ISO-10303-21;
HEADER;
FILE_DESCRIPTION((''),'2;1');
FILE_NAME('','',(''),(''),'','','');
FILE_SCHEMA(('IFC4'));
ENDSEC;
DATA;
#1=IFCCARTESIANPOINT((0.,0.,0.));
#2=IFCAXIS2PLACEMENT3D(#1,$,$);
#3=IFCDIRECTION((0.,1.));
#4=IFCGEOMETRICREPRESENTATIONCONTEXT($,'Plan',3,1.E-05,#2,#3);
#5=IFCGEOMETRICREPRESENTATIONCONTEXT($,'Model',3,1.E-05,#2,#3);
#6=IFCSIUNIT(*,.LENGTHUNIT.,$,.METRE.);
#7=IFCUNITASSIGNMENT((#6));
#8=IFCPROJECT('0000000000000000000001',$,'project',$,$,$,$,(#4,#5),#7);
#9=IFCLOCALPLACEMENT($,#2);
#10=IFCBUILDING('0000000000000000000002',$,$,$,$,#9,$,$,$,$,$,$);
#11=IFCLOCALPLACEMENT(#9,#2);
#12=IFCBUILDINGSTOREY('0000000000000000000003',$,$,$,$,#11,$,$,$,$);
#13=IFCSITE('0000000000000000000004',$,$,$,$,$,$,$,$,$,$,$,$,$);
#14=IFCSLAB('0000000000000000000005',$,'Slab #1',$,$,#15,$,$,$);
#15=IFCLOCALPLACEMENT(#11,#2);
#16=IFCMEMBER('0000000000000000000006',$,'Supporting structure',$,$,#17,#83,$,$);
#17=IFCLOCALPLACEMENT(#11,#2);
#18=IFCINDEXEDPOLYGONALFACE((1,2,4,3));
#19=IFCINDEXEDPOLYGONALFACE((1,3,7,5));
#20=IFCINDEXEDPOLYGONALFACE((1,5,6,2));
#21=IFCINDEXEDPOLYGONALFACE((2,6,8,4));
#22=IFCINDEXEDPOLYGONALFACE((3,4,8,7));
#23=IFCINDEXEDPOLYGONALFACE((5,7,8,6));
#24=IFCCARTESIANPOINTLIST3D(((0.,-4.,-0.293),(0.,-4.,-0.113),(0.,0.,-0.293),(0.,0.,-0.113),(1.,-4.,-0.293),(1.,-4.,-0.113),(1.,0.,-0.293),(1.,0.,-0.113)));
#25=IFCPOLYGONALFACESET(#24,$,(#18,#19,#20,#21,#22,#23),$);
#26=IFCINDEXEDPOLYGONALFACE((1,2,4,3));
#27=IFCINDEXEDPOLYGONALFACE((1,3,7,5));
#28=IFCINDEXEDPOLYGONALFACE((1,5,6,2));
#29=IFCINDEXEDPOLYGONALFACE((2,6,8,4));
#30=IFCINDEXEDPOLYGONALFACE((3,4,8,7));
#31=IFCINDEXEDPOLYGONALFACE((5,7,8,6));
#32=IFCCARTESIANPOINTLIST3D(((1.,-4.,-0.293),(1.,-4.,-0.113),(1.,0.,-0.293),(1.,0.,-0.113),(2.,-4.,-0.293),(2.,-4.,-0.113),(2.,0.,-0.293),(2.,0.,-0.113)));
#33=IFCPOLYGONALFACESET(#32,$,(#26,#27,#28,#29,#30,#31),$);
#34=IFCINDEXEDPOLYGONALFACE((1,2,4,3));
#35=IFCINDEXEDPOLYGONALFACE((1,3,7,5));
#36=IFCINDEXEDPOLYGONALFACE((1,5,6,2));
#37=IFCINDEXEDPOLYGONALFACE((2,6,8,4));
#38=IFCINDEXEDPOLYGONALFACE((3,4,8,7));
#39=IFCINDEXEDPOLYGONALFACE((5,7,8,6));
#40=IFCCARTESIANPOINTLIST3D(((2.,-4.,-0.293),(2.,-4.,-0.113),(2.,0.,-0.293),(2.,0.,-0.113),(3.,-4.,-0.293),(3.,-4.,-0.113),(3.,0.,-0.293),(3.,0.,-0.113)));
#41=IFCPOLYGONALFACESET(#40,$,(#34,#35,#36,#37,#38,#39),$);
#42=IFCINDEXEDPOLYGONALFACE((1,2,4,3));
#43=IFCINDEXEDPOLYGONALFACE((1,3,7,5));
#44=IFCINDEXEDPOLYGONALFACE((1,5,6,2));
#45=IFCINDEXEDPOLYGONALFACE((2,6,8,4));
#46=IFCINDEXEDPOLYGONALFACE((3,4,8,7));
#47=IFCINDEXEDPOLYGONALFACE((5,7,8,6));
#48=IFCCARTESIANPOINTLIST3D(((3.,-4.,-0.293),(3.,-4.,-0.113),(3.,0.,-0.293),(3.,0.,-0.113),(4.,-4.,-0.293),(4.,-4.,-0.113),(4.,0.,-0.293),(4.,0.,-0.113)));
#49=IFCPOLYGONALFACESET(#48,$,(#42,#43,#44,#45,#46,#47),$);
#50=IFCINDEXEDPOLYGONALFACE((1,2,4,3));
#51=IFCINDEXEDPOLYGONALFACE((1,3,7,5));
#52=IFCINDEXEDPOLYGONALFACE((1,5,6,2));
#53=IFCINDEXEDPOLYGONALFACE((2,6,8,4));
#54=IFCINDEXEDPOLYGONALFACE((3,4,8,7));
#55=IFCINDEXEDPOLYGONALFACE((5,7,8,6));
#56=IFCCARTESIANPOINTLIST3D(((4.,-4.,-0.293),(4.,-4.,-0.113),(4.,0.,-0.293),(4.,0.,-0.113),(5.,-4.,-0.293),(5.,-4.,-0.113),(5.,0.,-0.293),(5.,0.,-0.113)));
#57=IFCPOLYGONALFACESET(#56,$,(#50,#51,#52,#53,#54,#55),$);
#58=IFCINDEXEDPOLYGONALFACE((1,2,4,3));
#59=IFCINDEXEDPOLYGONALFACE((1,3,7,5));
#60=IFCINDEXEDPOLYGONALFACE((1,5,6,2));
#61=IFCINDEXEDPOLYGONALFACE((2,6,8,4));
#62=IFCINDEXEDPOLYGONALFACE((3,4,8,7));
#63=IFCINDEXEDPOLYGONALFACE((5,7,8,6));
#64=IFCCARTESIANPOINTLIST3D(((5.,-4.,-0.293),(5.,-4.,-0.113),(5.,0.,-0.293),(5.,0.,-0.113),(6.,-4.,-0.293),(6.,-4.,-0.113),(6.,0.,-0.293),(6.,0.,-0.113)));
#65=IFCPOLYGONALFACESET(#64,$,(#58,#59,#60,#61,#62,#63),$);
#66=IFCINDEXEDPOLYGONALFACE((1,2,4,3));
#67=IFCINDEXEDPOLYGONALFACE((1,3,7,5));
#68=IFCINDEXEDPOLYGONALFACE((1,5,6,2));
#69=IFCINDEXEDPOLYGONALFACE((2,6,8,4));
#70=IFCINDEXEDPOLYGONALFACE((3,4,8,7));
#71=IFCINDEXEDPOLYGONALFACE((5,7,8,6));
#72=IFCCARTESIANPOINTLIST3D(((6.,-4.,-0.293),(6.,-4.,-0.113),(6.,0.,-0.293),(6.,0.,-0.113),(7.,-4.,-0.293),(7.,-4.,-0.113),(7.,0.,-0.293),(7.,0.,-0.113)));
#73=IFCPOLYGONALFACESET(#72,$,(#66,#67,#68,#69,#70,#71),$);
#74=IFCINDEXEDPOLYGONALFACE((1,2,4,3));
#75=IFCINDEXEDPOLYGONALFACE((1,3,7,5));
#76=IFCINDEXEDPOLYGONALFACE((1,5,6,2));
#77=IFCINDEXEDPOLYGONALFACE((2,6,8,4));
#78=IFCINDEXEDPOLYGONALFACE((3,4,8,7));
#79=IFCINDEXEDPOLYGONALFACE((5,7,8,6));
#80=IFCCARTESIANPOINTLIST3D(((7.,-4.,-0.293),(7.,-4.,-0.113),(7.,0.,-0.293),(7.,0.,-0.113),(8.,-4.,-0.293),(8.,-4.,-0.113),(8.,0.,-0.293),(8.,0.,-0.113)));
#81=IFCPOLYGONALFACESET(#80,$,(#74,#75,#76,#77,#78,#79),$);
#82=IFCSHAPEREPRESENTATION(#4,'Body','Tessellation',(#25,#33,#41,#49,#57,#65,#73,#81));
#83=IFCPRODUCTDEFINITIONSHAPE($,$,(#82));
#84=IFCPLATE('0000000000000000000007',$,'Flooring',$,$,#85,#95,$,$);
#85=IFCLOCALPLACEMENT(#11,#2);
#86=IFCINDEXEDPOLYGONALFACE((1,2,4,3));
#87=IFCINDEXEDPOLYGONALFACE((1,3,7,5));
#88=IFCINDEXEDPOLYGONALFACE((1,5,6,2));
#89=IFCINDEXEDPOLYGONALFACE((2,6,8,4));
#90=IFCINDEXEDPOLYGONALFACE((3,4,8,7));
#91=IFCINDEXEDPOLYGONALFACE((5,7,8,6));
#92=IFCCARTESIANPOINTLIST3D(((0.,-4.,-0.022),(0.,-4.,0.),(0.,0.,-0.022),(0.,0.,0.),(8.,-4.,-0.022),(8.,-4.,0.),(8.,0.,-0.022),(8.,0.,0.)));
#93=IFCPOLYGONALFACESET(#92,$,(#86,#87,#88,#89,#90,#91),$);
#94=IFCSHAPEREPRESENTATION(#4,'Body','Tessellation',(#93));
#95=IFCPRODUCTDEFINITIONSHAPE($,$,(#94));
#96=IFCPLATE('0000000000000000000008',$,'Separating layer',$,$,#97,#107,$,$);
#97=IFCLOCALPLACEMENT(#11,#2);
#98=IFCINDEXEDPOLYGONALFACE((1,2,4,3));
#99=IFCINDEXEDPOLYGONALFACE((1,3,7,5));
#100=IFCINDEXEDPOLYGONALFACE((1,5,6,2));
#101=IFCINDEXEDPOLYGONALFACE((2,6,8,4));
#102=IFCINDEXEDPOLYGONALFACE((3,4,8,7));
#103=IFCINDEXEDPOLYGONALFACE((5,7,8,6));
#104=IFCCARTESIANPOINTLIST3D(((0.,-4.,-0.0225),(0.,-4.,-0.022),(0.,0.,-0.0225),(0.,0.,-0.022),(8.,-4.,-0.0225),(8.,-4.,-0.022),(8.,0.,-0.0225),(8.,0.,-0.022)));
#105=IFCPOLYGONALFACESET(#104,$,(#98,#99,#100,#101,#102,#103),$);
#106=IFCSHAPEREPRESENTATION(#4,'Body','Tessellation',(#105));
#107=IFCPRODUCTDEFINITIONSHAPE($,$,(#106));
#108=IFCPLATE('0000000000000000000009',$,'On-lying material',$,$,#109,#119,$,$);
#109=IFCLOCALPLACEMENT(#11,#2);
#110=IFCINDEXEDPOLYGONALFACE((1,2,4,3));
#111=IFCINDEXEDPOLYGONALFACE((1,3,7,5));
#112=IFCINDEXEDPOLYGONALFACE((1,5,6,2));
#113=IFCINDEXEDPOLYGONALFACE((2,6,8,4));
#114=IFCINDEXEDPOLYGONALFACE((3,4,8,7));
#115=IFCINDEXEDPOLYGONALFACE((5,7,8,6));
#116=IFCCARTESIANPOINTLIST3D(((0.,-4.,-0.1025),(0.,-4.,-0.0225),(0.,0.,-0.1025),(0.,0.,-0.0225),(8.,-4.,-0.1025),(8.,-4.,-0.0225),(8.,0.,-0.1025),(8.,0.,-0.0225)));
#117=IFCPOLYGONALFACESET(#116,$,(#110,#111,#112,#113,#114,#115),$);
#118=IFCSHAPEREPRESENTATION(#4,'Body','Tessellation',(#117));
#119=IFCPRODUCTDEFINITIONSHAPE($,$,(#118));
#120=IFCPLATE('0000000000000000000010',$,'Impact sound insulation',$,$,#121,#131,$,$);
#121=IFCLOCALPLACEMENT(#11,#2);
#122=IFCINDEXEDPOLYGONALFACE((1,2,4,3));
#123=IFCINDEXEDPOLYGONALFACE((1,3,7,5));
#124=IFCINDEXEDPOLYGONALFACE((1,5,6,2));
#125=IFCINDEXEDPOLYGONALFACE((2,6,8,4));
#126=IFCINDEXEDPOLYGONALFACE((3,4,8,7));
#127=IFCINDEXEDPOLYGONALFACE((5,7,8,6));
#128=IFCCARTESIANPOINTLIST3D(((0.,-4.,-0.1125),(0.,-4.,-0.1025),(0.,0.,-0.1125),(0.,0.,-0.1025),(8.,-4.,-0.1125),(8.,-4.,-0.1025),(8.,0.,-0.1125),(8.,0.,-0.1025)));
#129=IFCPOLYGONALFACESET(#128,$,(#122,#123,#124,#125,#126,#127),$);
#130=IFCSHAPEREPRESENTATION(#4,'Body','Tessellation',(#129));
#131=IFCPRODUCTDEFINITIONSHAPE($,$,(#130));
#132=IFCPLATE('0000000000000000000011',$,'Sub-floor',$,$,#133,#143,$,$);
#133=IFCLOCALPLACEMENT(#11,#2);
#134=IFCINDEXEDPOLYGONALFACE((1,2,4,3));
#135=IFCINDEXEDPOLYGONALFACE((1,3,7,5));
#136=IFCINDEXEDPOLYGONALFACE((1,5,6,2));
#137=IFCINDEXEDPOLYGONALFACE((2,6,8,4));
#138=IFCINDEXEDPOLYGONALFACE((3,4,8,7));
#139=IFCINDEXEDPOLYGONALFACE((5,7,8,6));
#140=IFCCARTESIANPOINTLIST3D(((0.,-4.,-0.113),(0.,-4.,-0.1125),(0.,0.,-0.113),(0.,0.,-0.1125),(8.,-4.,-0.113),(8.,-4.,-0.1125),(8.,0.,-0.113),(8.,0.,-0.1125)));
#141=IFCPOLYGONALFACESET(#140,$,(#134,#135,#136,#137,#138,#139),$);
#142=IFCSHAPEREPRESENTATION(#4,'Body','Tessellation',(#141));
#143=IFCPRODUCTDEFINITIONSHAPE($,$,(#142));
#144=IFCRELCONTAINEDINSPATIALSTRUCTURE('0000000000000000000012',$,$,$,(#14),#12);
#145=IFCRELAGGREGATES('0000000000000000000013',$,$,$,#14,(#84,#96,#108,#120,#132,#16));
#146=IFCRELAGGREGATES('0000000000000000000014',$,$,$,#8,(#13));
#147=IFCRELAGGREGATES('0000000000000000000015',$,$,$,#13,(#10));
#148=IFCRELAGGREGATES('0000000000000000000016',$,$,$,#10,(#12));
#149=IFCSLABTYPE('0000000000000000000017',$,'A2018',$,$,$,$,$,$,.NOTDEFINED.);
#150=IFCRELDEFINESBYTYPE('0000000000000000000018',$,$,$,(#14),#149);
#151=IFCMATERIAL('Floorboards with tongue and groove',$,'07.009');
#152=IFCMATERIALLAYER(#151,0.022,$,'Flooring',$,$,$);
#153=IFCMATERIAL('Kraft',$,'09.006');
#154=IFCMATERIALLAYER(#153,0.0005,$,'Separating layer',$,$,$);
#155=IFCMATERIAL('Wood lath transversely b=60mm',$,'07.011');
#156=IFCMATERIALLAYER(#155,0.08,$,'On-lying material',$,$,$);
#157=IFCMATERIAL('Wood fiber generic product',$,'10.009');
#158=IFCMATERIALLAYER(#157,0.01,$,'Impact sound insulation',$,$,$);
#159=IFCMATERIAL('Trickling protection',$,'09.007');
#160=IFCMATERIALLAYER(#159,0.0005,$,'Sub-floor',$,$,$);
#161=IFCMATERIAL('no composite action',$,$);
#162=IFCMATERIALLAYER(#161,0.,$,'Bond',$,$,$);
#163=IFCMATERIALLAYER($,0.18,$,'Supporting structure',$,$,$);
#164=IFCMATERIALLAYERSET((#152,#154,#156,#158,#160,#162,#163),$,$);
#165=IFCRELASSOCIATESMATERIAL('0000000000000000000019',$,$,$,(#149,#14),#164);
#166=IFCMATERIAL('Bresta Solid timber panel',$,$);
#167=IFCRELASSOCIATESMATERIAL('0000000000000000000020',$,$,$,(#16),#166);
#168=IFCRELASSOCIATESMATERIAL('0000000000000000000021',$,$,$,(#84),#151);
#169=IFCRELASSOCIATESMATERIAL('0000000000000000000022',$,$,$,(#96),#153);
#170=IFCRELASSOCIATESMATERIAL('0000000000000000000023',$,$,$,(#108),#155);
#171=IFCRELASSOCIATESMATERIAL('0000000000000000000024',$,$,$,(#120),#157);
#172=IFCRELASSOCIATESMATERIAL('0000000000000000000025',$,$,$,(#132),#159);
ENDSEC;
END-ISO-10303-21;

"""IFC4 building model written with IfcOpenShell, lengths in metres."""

from ifc_helpers import new_model, si_unit, direction, frame, frame_2d, origin, origin_with_axes, place, context, project, spatial, rectangle, extrude, material, layer, layer_set, type_object, element, aggregate, save


model = new_model("IFC4")

# Units and contexts
plan_context = context("Plan", 3, precision=1e-05, world=origin(), true_north=direction((0.0, 1.0)))
model_context = context("Model", 3, precision=1e-05, world=origin(), true_north=direction((0.0, 1.0)))
ifc_project = project(units=[si_unit("LENGTHUNIT", "METRE")], contexts=[plan_context, model_context])

# Site, building, storey
site = spatial("IfcSite", under=ifc_project)
building_placement = place(None, origin())
building = spatial("IfcBuilding", under=site, at=building_placement)
storey_placement = place(building_placement, origin())
storey = spatial("IfcBuildingStorey", under=building, at=storey_placement)

# Slab, member, plates
ifc_material_1 = material(Name="Floorboards with tongue and groove", Category="07.009")
ifc_layer_1 = layer(ifc_material_1, 0.022, Name="Flooring")
ifc_material_2 = material(Name="Kraft", Category="09.006")
ifc_layer_2 = layer(ifc_material_2, 0.0005, Name="Separating layer")
ifc_material_3 = material(Name="Wood lath transversely b=60mm", Category="07.011")
ifc_layer_3 = layer(ifc_material_3, 0.08, Name="On-lying material")
ifc_material_4 = material(Name="Wood fiber generic product", Category="10.009")
ifc_layer_4 = layer(ifc_material_4, 0.01, Name="Impact sound insulation")
ifc_material_5 = material(Name="Trickling protection", Category="09.007")
ifc_layer_5 = layer(ifc_material_5, 0.0005, Name="Sub-floor")
ifc_material_6 = material(Name="no composite action")
ifc_layer_6 = layer(ifc_material_6, 0.0, Name="Bond")
ifc_layer_7 = layer(None, 0.18, Name="Supporting structure")
ifc_layer_set = layer_set([ifc_layer_1, ifc_layer_2, ifc_layer_3, ifc_layer_4, ifc_layer_5, ifc_layer_6, ifc_layer_7])
slab_type = type_object("IfcSlabType", Name="A2018", PredefinedType="NOTDEFINED", material=ifc_layer_set)
slab_placement = place(None, frame((0.0, 0.0, 0.0), z_axis=(0.0, 0.0, -1.0), x_axis=(1.0, 0.0, 0.0)))
slab = element("IfcSlab", 1, at=slab_placement, inside=storey, type_object=slab_type, material=ifc_layer_set, Name="Slab #1")
ifc_material_7 = material(Name="Bresta Solid timber panel")
member_placement = place(slab_placement, origin())
member = element("IfcMember", 2, at=member_placement, material=ifc_material_7, Name="Supporting structure", context=plan_context, shape_type="SweptSolid", body=[
    extrude(rectangle(XDim=1.0, YDim=0.18, at=frame_2d((0.5, 0.09), x_axis=(1.0, 0.0))), frame((0.0, 4.0, 0.113), z_axis=(0.0, -1.0, 0.0), x_axis=(1.0, 0.0, 0.0)), (0.0, 0.0, 1.0), 4.0),
    extrude(rectangle(XDim=1.0, YDim=0.18, at=frame_2d((0.5, 0.09), x_axis=(1.0, 0.0))), frame((1.0, 4.0, 0.113), z_axis=(0.0, -1.0, 0.0), x_axis=(1.0, 0.0, 0.0)), (0.0, 0.0, 1.0), 4.0),
    extrude(rectangle(XDim=1.0, YDim=0.18, at=frame_2d((0.5, 0.09), x_axis=(1.0, 0.0))), frame((2.0, 4.0, 0.113), z_axis=(0.0, -1.0, 0.0), x_axis=(1.0, 0.0, 0.0)), (0.0, 0.0, 1.0), 4.0),
    extrude(rectangle(XDim=1.0, YDim=0.18, at=frame_2d((0.5, 0.09), x_axis=(1.0, 0.0))), frame((3.0, 4.0, 0.113), z_axis=(0.0, -1.0, 0.0), x_axis=(1.0, 0.0, 0.0)), (0.0, 0.0, 1.0), 4.0),
    extrude(rectangle(XDim=1.0, YDim=0.18, at=frame_2d((0.5, 0.09), x_axis=(1.0, 0.0))), frame((4.0, 4.0, 0.113), z_axis=(0.0, -1.0, 0.0), x_axis=(1.0, 0.0, 0.0)), (0.0, 0.0, 1.0), 4.0),
    extrude(rectangle(XDim=1.0, YDim=0.18, at=frame_2d((0.5, 0.09), x_axis=(1.0, 0.0))), frame((5.0, 4.0, 0.113), z_axis=(0.0, -1.0, 0.0), x_axis=(1.0, 0.0, 0.0)), (0.0, 0.0, 1.0), 4.0),
    extrude(rectangle(XDim=1.0, YDim=0.18, at=frame_2d((0.5, 0.09), x_axis=(1.0, 0.0))), frame((6.0, 4.0, 0.113), z_axis=(0.0, -1.0, 0.0), x_axis=(1.0, 0.0, 0.0)), (0.0, 0.0, 1.0), 4.0),
    extrude(rectangle(XDim=1.0, YDim=0.18, at=frame_2d((0.5, 0.09), x_axis=(1.0, 0.0))), frame((7.0, 4.0, 0.113), z_axis=(0.0, -1.0, 0.0), x_axis=(1.0, 0.0, 0.0)), (0.0, 0.0, 1.0), 4.0),
])
plate_1_placement = place(slab_placement, origin())
plate_1 = element("IfcPlate", 3, at=plate_1_placement, material=ifc_material_1, Name="Flooring", context=plan_context, shape_type="SweptSolid", body=[
    extrude(rectangle(XDim=8.0, YDim=4.0, at=frame_2d((4.0, 2.0), x_axis=(1.0, 0.0))), origin_with_axes(), (0.0, 0.0, 1.0), 0.022),
])
plate_2_placement = place(slab_placement, origin())
plate_2 = element("IfcPlate", 4, at=plate_2_placement, material=ifc_material_2, Name="Separating layer", context=plan_context, shape_type="SweptSolid", body=[
    extrude(rectangle(XDim=8.0, YDim=4.0, at=frame_2d((4.0, 2.0), x_axis=(1.0, 0.0))), frame((0.0, 0.0, 0.022), z_axis=(0.0, 0.0, 1.0), x_axis=(1.0, 0.0, 0.0)), (0.0, 0.0, 1.0), 0.0005),
])
plate_3_placement = place(slab_placement, origin())
plate_3 = element("IfcPlate", 5, at=plate_3_placement, material=ifc_material_3, Name="On-lying material", context=plan_context, shape_type="SweptSolid", body=[
    extrude(rectangle(XDim=8.0, YDim=4.0, at=frame_2d((4.0, 2.0), x_axis=(1.0, 0.0))), frame((0.0, 0.0, 0.0225), z_axis=(0.0, 0.0, 1.0), x_axis=(1.0, 0.0, 0.0)), (0.0, 0.0, 1.0), 0.08),
])
plate_4_placement = place(slab_placement, origin())
plate_4 = element("IfcPlate", 6, at=plate_4_placement, material=ifc_material_4, Name="Impact sound insulation", context=plan_context, shape_type="SweptSolid", body=[
    extrude(rectangle(XDim=8.0, YDim=4.0, at=frame_2d((4.0, 2.0), x_axis=(1.0, 0.0))), frame((0.0, 0.0, 0.1025), z_axis=(0.0, 0.0, 1.0), x_axis=(1.0, 0.0, 0.0)), (0.0, 0.0, 1.0), 0.01),
])
plate_5_placement = place(slab_placement, origin())
plate_5 = element("IfcPlate", 7, at=plate_5_placement, material=ifc_material_5, Name="Sub-floor", context=plan_context, shape_type="SweptSolid", body=[
    extrude(rectangle(XDim=8.0, YDim=4.0, at=frame_2d((4.0, 2.0), x_axis=(1.0, 0.0))), frame((0.0, 0.0, 0.1125), z_axis=(0.0, 0.0, 1.0), x_axis=(1.0, 0.0, 0.0)), (0.0, 0.0, 1.0), 0.0005),
])
aggregate(slab, [plate_1, plate_2, plate_3, plate_4, plate_5, member])

save(model, "model.ifc")
